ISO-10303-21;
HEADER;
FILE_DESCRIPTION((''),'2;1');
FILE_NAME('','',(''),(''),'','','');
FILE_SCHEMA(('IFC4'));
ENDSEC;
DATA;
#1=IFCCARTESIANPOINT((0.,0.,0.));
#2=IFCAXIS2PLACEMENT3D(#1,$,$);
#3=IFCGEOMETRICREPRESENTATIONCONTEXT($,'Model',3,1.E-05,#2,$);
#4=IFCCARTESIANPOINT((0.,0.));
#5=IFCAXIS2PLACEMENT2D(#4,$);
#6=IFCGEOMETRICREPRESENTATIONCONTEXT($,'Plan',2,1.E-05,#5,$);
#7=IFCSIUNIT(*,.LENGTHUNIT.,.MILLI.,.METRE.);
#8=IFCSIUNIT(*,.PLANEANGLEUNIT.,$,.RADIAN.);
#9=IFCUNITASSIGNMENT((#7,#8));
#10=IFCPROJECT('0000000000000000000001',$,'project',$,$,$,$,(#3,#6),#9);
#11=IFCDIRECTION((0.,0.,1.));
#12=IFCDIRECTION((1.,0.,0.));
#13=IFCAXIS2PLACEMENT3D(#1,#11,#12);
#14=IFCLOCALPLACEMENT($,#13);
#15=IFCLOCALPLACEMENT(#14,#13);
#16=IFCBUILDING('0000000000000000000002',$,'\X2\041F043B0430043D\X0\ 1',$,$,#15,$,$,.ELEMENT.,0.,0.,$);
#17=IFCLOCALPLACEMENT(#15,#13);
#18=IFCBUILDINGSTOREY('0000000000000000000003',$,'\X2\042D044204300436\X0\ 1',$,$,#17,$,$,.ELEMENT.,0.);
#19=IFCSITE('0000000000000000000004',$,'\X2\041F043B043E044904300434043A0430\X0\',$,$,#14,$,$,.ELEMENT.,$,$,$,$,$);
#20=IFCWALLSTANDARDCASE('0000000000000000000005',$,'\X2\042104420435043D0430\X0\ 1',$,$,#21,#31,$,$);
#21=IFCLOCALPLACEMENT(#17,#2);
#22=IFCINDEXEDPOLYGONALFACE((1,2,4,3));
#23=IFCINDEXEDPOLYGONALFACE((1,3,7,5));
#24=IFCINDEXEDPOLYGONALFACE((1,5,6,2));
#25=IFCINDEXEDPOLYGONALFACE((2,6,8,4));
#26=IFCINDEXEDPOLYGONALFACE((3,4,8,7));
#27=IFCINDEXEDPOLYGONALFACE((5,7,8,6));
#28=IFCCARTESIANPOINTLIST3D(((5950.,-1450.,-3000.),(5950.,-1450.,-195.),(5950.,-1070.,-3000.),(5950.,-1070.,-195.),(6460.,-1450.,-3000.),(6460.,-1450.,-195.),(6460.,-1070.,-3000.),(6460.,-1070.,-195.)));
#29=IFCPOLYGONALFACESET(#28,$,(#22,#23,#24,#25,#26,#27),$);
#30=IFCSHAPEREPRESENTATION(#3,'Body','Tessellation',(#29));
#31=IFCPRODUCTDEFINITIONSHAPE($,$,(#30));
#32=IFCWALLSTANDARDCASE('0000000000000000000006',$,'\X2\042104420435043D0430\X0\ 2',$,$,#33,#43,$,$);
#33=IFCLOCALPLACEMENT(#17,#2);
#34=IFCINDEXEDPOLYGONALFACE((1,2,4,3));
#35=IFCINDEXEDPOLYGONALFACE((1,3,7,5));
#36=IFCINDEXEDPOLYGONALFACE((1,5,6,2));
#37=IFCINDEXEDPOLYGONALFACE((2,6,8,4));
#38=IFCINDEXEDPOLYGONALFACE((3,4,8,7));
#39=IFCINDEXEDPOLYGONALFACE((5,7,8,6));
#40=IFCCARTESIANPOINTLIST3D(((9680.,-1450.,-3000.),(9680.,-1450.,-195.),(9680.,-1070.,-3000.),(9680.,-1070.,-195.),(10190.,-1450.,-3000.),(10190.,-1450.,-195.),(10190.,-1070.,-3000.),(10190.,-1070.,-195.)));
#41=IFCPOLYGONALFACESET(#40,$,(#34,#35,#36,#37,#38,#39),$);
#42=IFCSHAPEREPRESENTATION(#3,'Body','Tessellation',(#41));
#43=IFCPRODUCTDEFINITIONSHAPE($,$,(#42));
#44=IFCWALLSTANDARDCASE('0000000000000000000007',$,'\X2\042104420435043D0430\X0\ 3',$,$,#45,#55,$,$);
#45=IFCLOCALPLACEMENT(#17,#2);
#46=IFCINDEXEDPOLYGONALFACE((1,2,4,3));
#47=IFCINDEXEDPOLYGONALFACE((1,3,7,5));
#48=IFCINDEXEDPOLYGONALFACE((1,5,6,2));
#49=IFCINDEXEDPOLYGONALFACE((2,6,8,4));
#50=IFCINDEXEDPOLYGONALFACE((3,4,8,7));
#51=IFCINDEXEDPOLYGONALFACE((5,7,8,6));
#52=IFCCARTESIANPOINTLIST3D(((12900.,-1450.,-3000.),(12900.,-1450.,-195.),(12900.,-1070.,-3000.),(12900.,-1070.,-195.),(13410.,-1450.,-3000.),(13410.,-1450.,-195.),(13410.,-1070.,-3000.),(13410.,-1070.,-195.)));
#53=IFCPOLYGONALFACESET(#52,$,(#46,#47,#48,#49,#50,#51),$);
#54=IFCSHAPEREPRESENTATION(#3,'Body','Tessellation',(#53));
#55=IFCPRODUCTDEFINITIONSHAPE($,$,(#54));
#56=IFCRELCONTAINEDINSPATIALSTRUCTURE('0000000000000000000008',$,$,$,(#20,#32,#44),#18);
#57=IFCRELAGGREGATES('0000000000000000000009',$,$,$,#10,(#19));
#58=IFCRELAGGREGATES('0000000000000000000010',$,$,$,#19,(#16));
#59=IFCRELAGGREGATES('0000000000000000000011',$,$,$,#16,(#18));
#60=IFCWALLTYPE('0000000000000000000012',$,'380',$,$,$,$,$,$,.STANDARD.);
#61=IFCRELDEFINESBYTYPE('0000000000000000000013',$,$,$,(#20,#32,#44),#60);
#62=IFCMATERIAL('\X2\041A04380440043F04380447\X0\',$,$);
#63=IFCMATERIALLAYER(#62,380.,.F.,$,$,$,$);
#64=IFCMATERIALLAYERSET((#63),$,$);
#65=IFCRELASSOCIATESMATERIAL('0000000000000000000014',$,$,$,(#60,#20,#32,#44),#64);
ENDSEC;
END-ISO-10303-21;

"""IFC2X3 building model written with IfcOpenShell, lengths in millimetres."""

from ifc_helpers import new_model, si_unit, frame, origin, origin_with_axes, origin_2d, place, context, project, spatial, polyline, segment, composite_curve, outline, extrude, material, layer, layer_set, layer_usage, type_object, element, save


model = new_model("IFC2X3")

# Units and contexts
model_context = context("Model", 3, precision=1e-05, world=origin())
plan_context = context("Plan", 2, precision=1e-05, world=origin_2d())
ifc_project = project(units=[si_unit("LENGTHUNIT", "METRE", prefix="MILLI"), si_unit("PLANEANGLEUNIT", "RADIAN")], contexts=[model_context, plan_context])

# Site, building, storey
site_placement = place(None, origin_with_axes())
site = spatial("IfcSite", under=ifc_project, at=site_placement, Name="Площадка", CompositionType="ELEMENT")
building_placement = place(site_placement, origin_with_axes())
building = spatial("IfcBuilding", under=site, at=building_placement, Name="План 1", CompositionType="ELEMENT", ElevationOfRefHeight=0.0, ElevationOfTerrain=0.0)
storey_placement = place(building_placement, origin_with_axes())
storey = spatial("IfcBuildingStorey", under=building, at=storey_placement, Name="Этаж 1", CompositionType="ELEMENT", Elevation=0.0)

# Walls
ifc_material = material(Name="Кирпич")
ifc_layer = layer(ifc_material, 380.0, ventilated=False)
ifc_layer_set = layer_set([ifc_layer])
ifc_layer_usage_1 = layer_usage(ifc_layer_set, "AXIS2", "POSITIVE", 0.0)
wall_type = type_object("IfcWallType", Name="380", PredefinedType="STANDARD", material=ifc_layer_set)
wall_1_placement = place(storey_placement, frame((5950.0, -1450.0, -3000.0), z_axis=(0.0, 0.0, 1.0), x_axis=(1.0, 0.0, 0.0)))
element("IfcWallStandardCase", 1, at=wall_1_placement, inside=storey, type_object=wall_type, material=ifc_layer_usage_1, Name="Стена 1", context=model_context, shape_type="SweptSolid", body=[
    extrude(outline(composite_curve([segment(polyline([(0.0, 380.0), (0.0, 0.0)]), True, "CONTINUOUS"), segment(polyline([(0.0, 0.0), (510.0, 0.0)]), True, "CONTINUOUS"), segment(polyline([(510.0, 0.0), (510.0, 380.0)]), True, "CONTINUOUS"), segment(polyline([(510.0, 380.0), (0.0, 380.0)]), True, "CONTINUOUS")], self_intersect=False)), origin_with_axes(), (0.0, 0.0, 1.0), 2805.0),
])
ifc_layer_usage_2 = layer_usage(ifc_layer_set, "AXIS2", "POSITIVE", 0.0)
wall_2_placement = place(storey_placement, frame((9680.0, -1450.0, -3000.0), z_axis=(0.0, 0.0, 1.0), x_axis=(1.0, 0.0, 0.0)))
element("IfcWallStandardCase", 2, at=wall_2_placement, inside=storey, type_object=wall_type, material=ifc_layer_usage_2, Name="Стена 2", context=model_context, shape_type="SweptSolid", body=[
    extrude(outline(composite_curve([segment(polyline([(0.0, 380.0), (0.0, 0.0)]), True, "CONTINUOUS"), segment(polyline([(0.0, 0.0), (510.0, 0.0)]), True, "CONTINUOUS"), segment(polyline([(510.0, 0.0), (510.0, 380.0)]), True, "CONTINUOUS"), segment(polyline([(510.0, 380.0), (0.0, 380.0)]), True, "CONTINUOUS")], self_intersect=False)), origin_with_axes(), (0.0, 0.0, 1.0), 2805.0),
])
ifc_layer_usage_3 = layer_usage(ifc_layer_set, "AXIS2", "POSITIVE", 0.0)
wall_3_placement = place(storey_placement, frame((12900.0, -1450.0, -3000.0), z_axis=(0.0, 0.0, 1.0), x_axis=(1.0, 0.0, 0.0)))
element("IfcWallStandardCase", 3, at=wall_3_placement, inside=storey, type_object=wall_type, material=ifc_layer_usage_3, Name="Стена 3", context=model_context, shape_type="SweptSolid", body=[
    extrude(outline(composite_curve([segment(polyline([(0.0, 380.0), (0.0, 0.0)]), True, "CONTINUOUS"), segment(polyline([(0.0, 0.0), (510.0, 0.0)]), True, "CONTINUOUS"), segment(polyline([(510.0, 0.0), (510.0, 380.0)]), True, "CONTINUOUS"), segment(polyline([(510.0, 380.0), (0.0, 380.0)]), True, "CONTINUOUS")], self_intersect=False)), origin_with_axes(), (0.0, 0.0, 1.0), 2805.0),
])

save(model, "model.ifc")
